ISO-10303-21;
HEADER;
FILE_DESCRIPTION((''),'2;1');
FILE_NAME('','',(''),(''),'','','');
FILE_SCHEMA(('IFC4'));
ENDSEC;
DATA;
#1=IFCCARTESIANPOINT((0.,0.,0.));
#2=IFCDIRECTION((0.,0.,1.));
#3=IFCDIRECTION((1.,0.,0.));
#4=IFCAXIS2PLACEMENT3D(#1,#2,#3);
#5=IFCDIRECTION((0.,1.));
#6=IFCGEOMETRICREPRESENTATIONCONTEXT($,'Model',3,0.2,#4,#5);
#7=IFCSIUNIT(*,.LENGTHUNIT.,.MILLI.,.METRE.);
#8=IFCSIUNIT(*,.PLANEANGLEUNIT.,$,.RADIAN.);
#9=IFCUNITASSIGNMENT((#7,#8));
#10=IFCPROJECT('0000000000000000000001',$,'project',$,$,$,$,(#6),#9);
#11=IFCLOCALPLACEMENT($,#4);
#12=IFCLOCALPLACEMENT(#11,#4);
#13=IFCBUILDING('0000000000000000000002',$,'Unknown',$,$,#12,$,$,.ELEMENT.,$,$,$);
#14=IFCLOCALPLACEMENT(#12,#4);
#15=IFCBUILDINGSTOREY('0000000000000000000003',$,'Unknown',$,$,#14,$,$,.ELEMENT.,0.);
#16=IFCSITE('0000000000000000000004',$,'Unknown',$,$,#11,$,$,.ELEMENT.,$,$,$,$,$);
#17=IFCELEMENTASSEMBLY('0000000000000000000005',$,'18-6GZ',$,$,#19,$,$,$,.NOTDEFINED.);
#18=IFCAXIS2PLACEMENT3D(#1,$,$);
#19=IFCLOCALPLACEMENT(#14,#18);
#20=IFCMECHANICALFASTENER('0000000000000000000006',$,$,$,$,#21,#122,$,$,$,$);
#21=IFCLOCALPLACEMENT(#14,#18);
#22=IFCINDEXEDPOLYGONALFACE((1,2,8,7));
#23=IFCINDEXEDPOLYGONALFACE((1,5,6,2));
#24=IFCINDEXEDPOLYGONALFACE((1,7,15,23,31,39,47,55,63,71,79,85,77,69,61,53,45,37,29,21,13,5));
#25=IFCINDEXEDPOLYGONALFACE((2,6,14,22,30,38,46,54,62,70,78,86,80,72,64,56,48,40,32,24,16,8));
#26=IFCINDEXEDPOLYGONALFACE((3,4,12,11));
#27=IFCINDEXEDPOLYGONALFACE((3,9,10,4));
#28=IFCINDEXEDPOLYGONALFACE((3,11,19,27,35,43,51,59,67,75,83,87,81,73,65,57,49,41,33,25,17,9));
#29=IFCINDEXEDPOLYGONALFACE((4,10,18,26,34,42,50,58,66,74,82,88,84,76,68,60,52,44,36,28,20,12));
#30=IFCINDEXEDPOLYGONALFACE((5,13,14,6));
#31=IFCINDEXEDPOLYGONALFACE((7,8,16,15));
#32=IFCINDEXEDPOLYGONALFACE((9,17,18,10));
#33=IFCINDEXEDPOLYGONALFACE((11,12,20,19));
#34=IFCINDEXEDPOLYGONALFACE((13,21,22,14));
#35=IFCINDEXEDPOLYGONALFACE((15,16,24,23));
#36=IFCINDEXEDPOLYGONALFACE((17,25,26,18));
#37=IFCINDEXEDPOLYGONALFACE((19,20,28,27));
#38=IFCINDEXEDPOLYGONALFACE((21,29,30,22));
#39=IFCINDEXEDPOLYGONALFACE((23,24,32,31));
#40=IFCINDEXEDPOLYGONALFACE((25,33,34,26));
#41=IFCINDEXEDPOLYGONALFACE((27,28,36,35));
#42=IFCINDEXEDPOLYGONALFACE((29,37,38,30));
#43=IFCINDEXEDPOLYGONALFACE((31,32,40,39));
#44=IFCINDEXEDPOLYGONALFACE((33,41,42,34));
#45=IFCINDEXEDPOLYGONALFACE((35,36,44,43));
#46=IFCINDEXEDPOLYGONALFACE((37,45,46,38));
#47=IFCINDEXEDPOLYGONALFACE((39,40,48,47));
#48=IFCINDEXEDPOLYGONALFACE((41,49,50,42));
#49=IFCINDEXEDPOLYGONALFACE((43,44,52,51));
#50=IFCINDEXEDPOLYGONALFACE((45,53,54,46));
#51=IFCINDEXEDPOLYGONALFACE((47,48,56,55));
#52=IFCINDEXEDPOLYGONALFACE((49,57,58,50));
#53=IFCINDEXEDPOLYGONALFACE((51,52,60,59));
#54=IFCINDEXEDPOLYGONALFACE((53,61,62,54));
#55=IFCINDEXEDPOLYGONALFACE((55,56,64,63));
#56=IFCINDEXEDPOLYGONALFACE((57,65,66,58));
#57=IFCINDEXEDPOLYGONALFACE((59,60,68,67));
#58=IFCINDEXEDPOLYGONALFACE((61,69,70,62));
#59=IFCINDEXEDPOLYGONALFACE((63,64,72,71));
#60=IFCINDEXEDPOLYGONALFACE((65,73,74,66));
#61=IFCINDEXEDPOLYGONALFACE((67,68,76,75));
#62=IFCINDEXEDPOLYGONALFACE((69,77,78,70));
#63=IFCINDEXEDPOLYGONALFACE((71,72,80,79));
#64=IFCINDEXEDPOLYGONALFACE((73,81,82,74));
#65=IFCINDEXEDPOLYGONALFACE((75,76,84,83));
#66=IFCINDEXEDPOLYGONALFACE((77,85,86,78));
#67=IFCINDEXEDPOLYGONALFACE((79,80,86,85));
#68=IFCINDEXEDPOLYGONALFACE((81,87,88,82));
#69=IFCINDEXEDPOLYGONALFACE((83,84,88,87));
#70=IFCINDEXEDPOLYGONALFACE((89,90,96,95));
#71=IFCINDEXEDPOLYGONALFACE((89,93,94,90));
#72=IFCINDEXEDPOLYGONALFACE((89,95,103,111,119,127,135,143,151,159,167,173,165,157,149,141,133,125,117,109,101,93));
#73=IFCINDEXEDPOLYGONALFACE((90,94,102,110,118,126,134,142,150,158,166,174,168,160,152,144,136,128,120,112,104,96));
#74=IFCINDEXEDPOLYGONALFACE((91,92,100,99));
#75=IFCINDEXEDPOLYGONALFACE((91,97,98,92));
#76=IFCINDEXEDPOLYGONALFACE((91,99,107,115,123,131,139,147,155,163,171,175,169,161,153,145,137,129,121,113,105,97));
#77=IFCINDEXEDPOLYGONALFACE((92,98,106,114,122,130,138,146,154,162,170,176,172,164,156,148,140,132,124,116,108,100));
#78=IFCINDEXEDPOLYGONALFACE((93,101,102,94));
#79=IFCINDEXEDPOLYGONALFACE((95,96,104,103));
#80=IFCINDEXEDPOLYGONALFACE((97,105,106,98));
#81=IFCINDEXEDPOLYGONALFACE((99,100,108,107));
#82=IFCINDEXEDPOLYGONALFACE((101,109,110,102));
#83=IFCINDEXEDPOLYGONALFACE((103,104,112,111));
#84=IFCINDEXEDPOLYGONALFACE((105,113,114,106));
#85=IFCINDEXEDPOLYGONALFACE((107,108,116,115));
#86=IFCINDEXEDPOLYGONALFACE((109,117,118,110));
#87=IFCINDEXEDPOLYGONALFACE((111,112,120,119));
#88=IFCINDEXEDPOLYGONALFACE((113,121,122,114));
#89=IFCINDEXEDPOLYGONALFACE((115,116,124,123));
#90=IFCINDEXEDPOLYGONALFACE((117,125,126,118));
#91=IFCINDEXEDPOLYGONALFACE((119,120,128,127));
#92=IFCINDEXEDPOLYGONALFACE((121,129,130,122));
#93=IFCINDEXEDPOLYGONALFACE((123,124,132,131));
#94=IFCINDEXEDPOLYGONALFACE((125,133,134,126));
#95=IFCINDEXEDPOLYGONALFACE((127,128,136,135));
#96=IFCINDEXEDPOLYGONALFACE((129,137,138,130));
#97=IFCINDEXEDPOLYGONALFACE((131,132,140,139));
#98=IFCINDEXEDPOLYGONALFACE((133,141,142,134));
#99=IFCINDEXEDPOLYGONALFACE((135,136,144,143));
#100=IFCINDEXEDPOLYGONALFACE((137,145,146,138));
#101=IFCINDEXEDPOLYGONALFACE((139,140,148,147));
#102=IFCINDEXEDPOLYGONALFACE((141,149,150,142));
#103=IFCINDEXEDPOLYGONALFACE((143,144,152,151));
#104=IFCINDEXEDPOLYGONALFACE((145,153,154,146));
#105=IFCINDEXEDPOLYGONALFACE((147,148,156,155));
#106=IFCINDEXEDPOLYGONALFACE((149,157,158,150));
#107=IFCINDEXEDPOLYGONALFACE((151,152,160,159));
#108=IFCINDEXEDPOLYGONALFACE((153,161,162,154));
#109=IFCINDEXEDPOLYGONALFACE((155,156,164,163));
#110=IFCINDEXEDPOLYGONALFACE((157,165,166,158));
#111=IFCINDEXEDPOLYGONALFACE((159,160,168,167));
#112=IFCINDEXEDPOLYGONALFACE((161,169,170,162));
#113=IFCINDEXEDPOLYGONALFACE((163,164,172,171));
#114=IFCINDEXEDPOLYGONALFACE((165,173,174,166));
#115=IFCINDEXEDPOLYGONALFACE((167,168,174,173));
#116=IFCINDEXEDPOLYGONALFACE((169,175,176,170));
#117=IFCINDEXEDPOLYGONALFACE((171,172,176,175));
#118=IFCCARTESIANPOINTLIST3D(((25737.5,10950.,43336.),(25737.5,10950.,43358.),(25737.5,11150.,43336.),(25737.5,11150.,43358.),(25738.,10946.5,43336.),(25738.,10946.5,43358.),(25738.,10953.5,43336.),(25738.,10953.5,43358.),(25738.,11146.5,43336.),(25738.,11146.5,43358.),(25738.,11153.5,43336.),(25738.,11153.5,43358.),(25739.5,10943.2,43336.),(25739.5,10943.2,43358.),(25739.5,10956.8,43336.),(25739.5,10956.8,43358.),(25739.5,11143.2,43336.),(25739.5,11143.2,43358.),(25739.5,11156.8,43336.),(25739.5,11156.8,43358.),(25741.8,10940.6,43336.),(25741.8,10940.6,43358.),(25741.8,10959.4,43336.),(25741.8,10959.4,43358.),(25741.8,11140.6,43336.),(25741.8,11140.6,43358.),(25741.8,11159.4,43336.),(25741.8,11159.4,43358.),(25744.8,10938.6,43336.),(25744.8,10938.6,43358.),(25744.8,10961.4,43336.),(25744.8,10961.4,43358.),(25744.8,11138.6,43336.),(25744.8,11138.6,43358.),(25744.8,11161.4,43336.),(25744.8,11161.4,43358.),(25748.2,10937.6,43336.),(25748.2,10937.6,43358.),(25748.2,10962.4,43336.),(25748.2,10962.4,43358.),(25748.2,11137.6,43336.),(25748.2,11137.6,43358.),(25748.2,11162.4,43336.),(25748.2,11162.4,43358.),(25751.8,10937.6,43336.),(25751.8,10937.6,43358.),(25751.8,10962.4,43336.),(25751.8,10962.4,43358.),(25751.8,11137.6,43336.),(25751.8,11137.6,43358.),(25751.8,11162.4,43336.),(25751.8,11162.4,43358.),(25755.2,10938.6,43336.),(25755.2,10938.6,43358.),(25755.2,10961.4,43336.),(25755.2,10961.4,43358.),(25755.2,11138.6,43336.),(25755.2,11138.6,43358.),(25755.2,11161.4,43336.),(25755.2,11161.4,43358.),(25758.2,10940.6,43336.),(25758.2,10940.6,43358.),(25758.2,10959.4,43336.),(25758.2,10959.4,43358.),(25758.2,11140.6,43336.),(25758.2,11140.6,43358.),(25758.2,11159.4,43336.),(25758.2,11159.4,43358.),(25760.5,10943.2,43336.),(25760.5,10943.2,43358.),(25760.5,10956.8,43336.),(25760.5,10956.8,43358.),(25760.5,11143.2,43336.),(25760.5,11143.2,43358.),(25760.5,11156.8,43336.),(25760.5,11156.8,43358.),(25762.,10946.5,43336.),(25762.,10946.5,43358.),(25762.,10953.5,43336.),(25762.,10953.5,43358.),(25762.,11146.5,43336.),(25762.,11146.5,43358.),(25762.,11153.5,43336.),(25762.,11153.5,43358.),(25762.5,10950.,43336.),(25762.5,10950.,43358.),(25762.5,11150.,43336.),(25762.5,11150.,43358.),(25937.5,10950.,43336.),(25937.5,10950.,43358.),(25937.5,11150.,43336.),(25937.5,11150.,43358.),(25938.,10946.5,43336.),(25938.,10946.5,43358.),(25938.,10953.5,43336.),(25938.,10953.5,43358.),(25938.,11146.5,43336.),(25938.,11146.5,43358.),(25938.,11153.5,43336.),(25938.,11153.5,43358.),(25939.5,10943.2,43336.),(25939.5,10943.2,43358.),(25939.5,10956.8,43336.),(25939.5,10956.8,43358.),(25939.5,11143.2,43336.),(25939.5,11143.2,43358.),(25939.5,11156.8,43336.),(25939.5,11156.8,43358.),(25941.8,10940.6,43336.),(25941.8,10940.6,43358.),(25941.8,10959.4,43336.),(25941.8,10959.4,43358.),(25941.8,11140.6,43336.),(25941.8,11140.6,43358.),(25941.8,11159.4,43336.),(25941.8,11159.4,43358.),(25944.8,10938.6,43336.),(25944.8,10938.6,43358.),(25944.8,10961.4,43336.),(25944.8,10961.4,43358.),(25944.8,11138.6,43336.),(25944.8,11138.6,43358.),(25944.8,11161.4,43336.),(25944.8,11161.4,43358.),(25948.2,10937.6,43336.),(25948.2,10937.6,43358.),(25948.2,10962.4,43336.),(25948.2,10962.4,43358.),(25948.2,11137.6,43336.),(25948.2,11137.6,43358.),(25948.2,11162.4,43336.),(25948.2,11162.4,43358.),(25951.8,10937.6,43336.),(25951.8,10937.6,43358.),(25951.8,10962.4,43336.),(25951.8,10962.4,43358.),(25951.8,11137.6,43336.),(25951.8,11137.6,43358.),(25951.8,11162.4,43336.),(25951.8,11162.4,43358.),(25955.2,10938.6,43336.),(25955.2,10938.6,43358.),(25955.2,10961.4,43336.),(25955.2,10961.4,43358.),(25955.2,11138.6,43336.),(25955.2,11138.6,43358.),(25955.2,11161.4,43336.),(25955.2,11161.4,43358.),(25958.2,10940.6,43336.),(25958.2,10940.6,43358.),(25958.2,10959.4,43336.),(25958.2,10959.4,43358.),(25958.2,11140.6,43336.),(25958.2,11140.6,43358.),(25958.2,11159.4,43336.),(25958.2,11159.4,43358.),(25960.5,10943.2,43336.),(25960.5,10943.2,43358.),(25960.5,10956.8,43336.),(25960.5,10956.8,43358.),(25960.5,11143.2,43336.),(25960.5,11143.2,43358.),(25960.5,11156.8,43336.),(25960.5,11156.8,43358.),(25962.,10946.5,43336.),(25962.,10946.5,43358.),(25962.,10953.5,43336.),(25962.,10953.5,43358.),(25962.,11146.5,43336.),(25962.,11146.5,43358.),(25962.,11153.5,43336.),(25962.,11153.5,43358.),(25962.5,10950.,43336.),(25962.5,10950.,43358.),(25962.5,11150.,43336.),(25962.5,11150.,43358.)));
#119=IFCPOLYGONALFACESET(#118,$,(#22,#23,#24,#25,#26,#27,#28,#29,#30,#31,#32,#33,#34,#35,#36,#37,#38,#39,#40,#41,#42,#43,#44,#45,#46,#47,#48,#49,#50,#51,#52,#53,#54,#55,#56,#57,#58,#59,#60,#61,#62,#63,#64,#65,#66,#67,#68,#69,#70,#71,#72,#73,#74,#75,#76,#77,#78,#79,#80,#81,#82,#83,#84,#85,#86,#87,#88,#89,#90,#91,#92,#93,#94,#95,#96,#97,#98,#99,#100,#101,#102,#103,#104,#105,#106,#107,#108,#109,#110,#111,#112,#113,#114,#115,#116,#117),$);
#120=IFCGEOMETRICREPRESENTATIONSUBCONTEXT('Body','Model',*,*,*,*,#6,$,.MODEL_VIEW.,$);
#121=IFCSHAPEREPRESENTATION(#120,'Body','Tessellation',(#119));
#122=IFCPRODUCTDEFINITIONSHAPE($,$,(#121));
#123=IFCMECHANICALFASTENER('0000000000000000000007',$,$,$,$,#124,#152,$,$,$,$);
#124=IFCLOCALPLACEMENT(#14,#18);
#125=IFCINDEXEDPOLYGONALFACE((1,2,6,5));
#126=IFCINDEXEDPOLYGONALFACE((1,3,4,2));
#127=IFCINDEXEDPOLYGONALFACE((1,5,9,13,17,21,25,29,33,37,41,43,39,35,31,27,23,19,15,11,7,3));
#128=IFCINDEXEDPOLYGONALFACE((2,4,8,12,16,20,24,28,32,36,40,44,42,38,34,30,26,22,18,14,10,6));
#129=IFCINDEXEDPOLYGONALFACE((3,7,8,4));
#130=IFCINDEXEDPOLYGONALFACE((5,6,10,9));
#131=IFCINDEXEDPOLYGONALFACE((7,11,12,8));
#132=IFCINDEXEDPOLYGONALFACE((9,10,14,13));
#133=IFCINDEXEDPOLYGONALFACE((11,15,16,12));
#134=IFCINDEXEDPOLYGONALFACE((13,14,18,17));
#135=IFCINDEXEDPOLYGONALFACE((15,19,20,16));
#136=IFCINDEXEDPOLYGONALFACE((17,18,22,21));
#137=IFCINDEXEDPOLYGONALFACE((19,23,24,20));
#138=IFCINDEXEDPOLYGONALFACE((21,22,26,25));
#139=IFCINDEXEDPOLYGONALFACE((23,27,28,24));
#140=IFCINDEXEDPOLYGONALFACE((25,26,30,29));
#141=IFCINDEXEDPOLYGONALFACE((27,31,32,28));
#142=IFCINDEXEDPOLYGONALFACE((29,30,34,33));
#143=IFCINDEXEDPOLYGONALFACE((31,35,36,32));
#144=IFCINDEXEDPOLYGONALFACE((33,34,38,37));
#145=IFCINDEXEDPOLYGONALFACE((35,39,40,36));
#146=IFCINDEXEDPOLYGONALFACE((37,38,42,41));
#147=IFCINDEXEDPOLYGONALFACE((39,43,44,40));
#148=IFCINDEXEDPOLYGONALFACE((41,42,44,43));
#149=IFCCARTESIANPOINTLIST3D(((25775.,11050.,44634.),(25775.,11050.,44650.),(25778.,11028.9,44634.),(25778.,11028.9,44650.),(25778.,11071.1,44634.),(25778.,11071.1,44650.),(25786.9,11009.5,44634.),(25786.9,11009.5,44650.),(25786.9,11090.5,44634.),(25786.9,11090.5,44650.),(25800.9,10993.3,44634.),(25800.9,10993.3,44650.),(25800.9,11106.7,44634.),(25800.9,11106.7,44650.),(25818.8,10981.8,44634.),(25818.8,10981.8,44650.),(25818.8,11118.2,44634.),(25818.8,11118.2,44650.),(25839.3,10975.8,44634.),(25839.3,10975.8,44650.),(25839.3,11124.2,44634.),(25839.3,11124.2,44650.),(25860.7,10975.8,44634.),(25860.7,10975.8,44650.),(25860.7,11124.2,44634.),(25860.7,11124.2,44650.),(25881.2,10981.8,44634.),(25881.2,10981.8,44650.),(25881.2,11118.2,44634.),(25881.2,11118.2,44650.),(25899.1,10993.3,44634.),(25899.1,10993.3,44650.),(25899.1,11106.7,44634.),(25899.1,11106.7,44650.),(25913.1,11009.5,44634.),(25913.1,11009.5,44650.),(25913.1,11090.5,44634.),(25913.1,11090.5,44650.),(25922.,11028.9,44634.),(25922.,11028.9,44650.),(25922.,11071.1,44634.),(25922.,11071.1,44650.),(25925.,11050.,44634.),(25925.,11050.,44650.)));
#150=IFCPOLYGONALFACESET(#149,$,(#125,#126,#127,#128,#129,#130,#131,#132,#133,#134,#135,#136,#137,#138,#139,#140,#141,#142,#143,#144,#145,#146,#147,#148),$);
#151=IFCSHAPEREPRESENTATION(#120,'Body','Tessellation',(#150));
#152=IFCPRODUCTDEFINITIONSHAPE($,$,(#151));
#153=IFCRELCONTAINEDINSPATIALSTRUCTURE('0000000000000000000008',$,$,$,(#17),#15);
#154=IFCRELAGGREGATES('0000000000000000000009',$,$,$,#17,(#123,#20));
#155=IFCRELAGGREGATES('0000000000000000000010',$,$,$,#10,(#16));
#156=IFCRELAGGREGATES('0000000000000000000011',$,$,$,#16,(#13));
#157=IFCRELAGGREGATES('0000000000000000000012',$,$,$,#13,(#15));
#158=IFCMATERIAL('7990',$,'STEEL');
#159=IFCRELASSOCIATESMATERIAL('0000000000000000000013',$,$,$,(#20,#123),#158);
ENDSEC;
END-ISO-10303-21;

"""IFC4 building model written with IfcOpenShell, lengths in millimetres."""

from ifc_helpers import new_model, si_unit, direction, frame, origin_with_axes, place, context, subcontext, project, spatial, arc, indexed_curve, outline, extrude, source, transform, mapped, material, element, aggregate, save


model = new_model("IFC4")

# Units and contexts
model_context = context("Model", 3, precision=0.2, world=origin_with_axes(), true_north=direction((0.0, 1.0)))
body_context = subcontext(model_context, "Body", "Model", "MODEL_VIEW")
ifc_project = project(units=[si_unit("LENGTHUNIT", "METRE", prefix="MILLI"), si_unit("PLANEANGLEUNIT", "RADIAN")], contexts=[model_context])

# Site, building, storey
site_placement = place(None, origin_with_axes())
site = spatial("IfcSite", under=ifc_project, at=site_placement, Name="Unknown", CompositionType="ELEMENT")
building_placement = place(site_placement, origin_with_axes())
building = spatial("IfcBuilding", under=site, at=building_placement, Name="Unknown", CompositionType="ELEMENT")
storey_placement = place(building_placement, origin_with_axes())
storey = spatial("IfcBuildingStorey", under=building, at=storey_placement, Name="Unknown", CompositionType="ELEMENT", Elevation=0.0)

# Element assembly
assembly_1_placement = place(storey_placement, frame((25850.0, 11050.0, 35950.0), z_axis=(-1.0, 0.0, 0.0), x_axis=(0.0, 0.0, 1.0)))
assembly_1 = element("IfcElementAssembly", 1, at=assembly_1_placement, inside=storey, Name="18-6GZ", PredefinedType="NOTDEFINED")

# Mechanical fasteners
ifc_material_1 = material(Name="7990", Category="STEEL")
placement_1 = place(assembly_1_placement, frame((7408.0, 0.0, 0.0), z_axis=(1.0, 0.0, 0.0), x_axis=(0.0, 1.0, 0.0)))
shared_shape_1 = source(origin_with_axes(), body_context, "Body", "SweptSolid", [
    extrude(outline(indexed_curve([(12.5, 0.0), (0.0, 12.5), (-12.5, 0.0), (0.0, -12.5)], segments=[arc(1, 2, 3), arc(3, 4, 1)])), frame((0.0, 0.0, 0.0), z_axis=(0.0, 0.0, -1.0), x_axis=(0.0, 1.0, 0.0)), (0.0, 0.0, 1.0), 22.0),
])
mechanical_fastener_1 = element("IfcMechanicalFastener", 2, at=placement_1, material=ifc_material_1, context=body_context, shape_type="MappedRepresentation", body=[
    mapped(shared_shape_1, transform((-100.0, -100.0, 0.0))),
    mapped(shared_shape_1, transform((100.0, -100.0, 0.0))),
    mapped(shared_shape_1, transform((-100.0, 100.0, 0.0))),
    mapped(shared_shape_1, transform((100.0, 100.0, 0.0))),
])
shared_shape_2 = source(origin_with_axes(), body_context, "Body", "SweptSolid", [
    extrude(outline(indexed_curve([(75.0, 0.0), (0.0, 75.0), (-75.0, 0.0), (0.0, -75.0)], segments=[arc(1, 2, 3), arc(3, 4, 1)])), frame((0.0, 0.0, 0.0), z_axis=(0.0, 0.0, -1.0), x_axis=(0.0, 1.0, 0.0)), (0.0, 0.0, 1.0), 16.0),
])
placement_2 = place(assembly_1_placement, frame((8684.0, 0.0, 0.0), z_axis=(-1.0, 0.0, 0.0), x_axis=(0.0, 1.0, 0.0)))
mechanical_fastener_2 = element("IfcMechanicalFastener", 3, at=placement_2, material=ifc_material_1, context=body_context, shape_type="MappedRepresentation", body=[
    mapped(shared_shape_2, transform((0.0, 0.0, 0.0))),
])
aggregate(assembly_1, [mechanical_fastener_2, mechanical_fastener_1])

save(model, "model.ifc")
